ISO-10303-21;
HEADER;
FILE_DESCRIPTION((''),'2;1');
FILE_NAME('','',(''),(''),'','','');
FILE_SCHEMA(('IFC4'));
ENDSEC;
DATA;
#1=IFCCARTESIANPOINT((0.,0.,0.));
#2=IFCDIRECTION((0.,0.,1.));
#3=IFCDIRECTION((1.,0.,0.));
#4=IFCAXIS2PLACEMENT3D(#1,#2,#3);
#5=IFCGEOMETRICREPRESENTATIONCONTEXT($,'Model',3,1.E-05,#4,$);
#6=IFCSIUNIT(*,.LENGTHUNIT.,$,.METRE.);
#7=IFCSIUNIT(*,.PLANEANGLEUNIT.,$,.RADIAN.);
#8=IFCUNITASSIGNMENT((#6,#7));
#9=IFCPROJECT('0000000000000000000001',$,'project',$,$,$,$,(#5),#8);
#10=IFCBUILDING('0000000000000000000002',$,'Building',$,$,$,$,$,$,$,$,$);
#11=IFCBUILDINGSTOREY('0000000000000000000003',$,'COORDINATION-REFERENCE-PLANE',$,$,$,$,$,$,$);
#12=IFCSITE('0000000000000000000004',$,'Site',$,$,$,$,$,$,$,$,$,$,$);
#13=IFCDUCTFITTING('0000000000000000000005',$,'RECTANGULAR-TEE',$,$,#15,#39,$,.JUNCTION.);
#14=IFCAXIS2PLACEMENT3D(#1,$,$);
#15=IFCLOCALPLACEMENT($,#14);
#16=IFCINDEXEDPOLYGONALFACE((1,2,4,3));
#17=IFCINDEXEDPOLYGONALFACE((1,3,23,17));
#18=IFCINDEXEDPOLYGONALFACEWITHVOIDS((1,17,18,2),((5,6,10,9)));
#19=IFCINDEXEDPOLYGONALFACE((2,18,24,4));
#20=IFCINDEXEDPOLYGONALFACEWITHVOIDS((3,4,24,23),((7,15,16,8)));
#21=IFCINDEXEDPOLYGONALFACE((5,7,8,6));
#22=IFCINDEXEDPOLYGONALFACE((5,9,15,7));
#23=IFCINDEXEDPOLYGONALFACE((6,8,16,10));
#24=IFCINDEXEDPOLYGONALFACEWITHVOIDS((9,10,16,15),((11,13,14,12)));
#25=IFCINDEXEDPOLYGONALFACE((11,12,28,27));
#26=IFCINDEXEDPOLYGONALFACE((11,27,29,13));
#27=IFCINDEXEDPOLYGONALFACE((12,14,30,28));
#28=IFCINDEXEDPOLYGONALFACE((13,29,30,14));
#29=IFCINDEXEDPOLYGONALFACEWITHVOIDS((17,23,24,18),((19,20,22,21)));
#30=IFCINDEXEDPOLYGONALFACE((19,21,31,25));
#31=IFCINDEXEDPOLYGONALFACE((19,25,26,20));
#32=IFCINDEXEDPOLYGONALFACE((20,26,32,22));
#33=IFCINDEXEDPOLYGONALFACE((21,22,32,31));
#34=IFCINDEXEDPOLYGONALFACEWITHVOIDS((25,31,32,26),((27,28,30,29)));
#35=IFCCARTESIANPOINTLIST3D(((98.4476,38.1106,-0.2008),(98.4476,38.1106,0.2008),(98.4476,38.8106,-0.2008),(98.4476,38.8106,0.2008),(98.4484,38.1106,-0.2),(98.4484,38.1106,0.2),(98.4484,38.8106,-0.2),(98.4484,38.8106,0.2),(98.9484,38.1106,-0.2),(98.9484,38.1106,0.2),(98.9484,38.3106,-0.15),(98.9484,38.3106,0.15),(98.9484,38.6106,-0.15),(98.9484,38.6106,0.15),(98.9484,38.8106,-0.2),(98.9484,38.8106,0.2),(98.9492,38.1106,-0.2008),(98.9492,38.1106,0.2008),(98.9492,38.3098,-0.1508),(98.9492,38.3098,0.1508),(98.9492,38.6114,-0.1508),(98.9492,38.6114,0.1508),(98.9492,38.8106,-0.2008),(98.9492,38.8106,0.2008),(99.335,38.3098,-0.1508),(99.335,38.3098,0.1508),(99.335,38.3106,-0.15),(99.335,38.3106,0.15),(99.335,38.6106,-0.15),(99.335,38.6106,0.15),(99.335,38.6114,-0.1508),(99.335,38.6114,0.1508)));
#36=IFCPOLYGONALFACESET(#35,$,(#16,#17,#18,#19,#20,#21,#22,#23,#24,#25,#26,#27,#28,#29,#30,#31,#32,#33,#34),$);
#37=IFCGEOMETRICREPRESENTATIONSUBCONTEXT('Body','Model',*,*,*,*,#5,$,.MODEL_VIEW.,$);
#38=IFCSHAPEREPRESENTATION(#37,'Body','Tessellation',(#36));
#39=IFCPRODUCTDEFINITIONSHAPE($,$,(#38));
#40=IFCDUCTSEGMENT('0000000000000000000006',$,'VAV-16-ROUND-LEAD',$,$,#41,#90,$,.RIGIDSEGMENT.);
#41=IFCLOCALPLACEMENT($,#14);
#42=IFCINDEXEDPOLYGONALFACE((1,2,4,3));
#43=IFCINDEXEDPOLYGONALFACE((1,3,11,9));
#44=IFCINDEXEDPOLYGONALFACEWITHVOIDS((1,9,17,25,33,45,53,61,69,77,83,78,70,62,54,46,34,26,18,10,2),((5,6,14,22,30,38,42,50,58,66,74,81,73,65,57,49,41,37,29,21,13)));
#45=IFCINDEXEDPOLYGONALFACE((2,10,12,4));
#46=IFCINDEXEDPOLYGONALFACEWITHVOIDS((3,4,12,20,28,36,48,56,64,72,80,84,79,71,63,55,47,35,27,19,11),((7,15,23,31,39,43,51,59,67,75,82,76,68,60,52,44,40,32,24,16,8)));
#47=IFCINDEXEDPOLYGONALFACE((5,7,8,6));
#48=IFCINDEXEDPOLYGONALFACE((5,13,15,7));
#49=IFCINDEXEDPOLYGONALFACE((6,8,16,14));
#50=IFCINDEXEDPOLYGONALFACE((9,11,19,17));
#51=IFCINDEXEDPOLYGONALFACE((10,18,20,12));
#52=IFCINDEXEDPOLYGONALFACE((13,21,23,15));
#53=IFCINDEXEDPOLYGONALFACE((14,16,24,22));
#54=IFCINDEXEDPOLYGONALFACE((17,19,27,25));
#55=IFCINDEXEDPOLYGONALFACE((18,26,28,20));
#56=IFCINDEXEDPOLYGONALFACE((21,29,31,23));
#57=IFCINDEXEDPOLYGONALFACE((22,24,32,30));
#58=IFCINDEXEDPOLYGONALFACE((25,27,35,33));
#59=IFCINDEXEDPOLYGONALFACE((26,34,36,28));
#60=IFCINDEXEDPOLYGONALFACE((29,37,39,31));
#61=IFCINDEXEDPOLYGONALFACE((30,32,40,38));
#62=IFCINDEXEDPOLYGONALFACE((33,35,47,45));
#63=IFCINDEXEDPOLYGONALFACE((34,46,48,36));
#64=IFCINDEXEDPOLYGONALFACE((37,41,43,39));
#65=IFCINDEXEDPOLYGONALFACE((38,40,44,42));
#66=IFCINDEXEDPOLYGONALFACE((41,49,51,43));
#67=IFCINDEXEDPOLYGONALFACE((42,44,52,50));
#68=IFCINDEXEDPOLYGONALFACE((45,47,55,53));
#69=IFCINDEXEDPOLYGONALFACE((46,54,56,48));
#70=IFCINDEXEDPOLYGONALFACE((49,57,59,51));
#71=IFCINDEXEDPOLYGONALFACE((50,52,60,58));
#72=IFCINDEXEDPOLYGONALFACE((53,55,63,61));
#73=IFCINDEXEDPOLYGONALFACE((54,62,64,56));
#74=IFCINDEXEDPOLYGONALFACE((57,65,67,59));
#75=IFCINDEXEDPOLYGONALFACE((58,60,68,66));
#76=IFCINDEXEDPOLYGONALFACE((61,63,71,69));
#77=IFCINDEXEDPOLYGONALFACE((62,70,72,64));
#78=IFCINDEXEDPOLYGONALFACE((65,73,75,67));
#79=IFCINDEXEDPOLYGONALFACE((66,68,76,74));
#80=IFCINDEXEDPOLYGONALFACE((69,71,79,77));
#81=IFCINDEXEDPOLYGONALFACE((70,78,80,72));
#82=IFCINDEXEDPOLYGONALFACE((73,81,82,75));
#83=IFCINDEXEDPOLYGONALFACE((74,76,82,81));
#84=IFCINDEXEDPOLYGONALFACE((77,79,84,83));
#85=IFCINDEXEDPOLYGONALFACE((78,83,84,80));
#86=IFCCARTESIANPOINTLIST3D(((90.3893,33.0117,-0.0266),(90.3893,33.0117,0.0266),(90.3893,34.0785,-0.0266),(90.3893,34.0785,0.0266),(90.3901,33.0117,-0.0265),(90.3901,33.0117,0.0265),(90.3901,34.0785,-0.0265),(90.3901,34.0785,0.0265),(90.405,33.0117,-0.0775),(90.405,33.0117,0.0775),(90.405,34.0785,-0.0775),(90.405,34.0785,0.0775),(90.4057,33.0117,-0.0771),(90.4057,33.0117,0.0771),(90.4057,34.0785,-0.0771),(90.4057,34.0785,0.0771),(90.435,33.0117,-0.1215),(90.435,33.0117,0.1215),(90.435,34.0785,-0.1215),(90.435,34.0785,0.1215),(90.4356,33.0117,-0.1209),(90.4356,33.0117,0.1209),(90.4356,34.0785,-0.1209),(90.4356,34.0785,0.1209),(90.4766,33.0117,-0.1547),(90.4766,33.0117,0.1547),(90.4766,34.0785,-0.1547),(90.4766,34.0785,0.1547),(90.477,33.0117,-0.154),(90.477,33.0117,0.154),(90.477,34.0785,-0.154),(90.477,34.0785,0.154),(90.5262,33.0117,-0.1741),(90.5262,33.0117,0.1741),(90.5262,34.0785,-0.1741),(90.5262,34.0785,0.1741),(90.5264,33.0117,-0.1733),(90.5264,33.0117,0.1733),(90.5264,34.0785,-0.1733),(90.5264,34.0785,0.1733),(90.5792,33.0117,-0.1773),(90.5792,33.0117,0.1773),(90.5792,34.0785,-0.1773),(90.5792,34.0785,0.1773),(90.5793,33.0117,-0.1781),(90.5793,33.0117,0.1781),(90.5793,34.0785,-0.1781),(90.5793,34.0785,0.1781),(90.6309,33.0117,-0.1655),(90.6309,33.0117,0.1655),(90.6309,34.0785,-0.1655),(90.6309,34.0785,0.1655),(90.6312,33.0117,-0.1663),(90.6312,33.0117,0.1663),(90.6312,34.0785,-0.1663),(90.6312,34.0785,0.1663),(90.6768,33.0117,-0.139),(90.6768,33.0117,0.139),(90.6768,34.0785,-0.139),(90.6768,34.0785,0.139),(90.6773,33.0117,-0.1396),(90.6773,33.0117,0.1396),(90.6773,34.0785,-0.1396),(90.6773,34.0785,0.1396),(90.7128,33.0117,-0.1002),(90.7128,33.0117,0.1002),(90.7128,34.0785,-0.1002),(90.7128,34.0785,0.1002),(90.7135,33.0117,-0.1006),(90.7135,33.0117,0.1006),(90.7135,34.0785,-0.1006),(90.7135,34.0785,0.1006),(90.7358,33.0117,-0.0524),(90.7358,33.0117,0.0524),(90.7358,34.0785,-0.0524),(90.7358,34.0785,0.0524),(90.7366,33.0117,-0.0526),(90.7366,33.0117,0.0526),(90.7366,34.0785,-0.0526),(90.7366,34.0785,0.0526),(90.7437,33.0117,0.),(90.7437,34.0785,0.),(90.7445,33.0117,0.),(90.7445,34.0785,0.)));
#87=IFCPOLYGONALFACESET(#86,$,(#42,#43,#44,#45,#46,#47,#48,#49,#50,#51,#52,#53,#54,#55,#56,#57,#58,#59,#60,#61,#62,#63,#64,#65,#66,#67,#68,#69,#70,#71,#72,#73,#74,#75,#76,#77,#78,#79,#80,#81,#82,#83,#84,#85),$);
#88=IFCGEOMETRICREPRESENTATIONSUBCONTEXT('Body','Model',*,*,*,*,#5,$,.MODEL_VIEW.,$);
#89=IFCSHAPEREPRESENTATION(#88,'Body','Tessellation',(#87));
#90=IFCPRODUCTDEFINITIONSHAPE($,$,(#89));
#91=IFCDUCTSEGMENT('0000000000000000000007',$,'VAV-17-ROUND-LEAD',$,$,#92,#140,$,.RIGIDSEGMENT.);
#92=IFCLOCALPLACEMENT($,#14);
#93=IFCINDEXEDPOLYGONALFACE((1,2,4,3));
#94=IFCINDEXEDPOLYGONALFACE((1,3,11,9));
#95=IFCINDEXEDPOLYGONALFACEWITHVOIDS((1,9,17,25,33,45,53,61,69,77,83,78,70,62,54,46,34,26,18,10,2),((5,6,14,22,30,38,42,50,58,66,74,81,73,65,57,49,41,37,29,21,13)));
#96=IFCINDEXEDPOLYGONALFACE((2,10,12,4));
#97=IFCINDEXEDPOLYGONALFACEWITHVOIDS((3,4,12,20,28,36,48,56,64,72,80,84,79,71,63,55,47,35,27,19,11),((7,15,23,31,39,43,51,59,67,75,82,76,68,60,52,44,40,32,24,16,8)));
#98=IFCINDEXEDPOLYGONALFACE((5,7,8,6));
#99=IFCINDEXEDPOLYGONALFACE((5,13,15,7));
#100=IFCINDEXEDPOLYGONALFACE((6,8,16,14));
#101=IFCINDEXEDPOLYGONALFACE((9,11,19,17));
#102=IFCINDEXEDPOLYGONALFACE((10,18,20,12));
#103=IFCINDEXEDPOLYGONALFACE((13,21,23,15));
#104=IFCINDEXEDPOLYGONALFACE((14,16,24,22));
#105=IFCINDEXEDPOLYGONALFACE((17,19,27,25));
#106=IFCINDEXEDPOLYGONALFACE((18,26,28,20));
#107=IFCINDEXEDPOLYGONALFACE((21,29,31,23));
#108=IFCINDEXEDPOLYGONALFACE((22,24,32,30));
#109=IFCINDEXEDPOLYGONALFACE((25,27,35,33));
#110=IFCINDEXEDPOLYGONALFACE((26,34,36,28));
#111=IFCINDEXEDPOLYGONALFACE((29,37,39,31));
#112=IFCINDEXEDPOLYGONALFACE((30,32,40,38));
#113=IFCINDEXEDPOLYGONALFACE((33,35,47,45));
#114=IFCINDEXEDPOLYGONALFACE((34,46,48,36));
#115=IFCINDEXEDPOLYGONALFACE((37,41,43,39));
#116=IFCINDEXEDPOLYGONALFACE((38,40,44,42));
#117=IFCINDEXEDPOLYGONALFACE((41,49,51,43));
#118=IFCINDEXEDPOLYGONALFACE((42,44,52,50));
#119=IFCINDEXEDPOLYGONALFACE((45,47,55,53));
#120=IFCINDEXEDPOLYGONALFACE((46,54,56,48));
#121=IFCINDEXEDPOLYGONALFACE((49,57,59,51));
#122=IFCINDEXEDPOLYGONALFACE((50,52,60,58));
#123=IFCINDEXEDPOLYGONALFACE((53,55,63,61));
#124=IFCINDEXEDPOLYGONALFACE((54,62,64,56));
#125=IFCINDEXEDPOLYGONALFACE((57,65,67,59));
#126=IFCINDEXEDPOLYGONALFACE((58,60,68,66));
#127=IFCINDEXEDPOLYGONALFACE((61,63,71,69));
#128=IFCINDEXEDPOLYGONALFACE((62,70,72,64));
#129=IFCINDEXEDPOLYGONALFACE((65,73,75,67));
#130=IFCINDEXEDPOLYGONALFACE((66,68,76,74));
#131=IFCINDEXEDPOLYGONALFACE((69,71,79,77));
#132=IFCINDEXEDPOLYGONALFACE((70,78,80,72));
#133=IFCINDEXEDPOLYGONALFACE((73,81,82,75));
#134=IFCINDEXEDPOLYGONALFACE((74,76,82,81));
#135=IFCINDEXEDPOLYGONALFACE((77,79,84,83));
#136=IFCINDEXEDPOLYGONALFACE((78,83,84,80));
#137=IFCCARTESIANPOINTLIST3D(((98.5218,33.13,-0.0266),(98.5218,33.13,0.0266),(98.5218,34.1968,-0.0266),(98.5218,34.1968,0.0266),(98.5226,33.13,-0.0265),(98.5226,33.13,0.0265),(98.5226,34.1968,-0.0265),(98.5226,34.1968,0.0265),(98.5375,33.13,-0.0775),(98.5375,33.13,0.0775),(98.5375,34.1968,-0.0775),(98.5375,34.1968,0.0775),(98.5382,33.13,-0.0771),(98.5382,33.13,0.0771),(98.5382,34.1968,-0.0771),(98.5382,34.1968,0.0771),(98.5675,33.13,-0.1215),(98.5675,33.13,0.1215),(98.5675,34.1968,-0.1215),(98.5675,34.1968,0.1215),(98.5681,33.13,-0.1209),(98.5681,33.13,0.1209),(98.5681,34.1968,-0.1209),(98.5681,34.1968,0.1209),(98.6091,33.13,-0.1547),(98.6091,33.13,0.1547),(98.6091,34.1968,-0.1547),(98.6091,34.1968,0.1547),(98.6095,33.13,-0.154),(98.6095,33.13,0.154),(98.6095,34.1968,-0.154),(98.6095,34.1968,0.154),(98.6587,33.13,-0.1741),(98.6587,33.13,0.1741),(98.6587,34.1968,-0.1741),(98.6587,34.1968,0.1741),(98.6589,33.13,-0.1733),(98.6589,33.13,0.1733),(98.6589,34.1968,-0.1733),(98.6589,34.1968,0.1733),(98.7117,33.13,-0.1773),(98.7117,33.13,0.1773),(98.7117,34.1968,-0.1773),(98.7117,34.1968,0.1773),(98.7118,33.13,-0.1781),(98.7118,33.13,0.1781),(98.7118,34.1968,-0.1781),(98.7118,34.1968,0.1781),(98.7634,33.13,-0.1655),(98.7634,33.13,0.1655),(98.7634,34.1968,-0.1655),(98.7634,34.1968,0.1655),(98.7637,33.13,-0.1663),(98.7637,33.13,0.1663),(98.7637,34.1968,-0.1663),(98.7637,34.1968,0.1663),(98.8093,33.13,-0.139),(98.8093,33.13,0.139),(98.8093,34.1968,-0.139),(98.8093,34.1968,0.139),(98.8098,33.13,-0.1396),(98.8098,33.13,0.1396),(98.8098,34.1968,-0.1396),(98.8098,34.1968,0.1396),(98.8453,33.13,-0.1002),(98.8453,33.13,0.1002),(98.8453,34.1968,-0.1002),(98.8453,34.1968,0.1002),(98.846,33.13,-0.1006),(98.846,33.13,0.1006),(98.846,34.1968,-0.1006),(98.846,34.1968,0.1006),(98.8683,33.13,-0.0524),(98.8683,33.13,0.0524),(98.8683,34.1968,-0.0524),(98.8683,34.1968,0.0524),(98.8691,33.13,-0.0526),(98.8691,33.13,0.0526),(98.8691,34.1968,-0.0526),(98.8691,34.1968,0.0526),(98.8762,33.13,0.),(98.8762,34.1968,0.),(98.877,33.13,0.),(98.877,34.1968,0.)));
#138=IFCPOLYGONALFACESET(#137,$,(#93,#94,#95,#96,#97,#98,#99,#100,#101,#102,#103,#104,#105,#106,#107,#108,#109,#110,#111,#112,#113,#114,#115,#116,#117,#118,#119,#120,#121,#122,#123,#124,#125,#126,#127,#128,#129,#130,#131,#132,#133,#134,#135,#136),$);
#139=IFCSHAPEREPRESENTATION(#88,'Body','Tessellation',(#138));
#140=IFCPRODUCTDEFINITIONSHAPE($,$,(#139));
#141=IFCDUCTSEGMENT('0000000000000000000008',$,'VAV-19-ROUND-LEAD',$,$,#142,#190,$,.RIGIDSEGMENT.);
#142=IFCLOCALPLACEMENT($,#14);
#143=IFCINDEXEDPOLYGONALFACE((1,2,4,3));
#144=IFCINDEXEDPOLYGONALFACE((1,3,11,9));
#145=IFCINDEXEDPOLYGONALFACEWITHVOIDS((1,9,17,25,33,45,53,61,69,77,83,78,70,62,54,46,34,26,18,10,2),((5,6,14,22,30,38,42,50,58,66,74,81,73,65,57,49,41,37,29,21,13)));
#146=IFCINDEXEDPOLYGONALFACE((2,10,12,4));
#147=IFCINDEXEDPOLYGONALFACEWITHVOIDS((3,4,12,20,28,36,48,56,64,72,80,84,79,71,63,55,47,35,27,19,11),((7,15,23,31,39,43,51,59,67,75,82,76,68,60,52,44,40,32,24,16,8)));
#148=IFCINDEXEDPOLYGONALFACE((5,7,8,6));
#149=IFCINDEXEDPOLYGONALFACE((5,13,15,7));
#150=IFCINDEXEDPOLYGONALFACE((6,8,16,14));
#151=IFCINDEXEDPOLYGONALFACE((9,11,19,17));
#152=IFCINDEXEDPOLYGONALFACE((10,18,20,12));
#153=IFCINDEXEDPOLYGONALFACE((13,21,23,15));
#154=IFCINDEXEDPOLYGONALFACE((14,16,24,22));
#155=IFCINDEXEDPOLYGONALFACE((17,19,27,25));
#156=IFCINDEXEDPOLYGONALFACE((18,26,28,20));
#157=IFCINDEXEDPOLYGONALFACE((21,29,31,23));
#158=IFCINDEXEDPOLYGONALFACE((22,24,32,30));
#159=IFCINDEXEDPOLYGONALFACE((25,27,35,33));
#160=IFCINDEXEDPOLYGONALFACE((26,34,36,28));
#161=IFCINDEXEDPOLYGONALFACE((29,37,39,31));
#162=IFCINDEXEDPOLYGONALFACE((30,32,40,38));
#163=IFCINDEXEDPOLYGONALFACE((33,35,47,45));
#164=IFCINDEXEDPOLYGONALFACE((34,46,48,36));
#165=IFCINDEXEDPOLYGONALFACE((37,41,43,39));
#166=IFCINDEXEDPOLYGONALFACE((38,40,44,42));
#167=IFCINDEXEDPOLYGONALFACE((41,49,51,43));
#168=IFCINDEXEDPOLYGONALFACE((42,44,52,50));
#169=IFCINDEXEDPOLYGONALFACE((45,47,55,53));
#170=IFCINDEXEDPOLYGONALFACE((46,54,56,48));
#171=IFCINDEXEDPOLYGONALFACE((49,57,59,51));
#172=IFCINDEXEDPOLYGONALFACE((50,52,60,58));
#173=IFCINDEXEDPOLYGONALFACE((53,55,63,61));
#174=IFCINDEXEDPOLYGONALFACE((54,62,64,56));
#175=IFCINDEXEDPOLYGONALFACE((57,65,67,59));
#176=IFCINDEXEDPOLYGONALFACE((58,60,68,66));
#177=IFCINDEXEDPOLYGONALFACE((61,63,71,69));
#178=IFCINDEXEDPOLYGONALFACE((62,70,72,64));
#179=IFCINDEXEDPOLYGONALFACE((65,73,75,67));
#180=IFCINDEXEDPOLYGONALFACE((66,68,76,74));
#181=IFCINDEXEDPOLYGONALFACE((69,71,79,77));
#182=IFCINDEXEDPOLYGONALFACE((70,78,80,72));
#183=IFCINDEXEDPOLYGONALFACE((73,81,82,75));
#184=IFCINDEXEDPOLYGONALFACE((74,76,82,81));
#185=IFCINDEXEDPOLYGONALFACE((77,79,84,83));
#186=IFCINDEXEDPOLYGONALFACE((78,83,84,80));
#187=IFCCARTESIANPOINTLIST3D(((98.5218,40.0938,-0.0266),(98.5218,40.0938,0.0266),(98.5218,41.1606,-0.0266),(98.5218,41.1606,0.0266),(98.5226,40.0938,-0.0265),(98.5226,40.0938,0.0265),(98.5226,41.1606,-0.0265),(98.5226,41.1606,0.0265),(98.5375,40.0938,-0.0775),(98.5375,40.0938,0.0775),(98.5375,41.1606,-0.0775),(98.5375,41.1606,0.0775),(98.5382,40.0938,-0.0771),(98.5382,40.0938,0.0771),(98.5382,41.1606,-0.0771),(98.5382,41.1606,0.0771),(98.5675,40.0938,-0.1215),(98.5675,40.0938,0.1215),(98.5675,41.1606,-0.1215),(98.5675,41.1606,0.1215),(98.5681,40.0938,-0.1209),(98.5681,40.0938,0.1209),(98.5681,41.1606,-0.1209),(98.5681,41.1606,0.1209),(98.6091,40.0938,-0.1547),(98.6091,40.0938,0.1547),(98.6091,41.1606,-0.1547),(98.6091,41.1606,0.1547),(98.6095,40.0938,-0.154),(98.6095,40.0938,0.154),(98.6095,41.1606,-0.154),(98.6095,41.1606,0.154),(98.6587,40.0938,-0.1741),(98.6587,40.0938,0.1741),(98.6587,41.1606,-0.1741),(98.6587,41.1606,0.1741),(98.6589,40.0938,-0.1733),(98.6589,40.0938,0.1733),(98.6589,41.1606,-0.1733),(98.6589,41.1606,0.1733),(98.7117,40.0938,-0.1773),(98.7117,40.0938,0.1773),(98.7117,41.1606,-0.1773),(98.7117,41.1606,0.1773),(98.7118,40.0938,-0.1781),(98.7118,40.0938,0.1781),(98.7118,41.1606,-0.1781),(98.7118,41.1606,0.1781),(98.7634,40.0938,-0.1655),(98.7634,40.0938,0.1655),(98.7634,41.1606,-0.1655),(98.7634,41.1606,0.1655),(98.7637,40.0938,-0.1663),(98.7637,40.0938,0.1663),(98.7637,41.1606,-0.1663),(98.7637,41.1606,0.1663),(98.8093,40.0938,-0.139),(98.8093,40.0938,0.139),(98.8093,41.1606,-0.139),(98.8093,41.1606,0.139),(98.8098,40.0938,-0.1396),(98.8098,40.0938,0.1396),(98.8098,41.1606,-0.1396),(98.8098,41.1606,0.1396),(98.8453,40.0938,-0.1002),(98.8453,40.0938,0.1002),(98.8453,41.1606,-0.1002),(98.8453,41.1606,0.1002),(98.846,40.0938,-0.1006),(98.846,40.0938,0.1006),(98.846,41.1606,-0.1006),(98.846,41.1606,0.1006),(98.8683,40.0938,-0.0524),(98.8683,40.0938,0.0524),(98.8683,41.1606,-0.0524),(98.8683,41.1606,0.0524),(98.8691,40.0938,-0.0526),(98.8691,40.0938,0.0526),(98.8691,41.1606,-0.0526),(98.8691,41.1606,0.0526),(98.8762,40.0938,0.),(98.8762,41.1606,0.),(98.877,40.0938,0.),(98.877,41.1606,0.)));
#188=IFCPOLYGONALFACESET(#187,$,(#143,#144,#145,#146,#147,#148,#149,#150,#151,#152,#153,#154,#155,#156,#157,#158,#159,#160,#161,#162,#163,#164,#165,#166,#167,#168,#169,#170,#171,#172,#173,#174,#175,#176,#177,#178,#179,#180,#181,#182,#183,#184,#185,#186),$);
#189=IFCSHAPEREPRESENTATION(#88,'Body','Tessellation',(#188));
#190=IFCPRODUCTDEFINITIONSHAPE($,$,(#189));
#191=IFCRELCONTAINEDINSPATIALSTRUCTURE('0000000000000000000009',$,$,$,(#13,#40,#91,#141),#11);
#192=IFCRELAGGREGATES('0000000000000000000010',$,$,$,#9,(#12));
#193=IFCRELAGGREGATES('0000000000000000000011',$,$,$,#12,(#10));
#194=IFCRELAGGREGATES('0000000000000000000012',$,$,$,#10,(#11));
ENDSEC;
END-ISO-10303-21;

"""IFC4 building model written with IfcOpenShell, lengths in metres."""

from ifc_helpers import new_model, si_unit, frame, origin, origin_with_axes, place, context, subcontext, project, spatial, rectangle, hollow_circle, extrude, boolean, element, save


model = new_model("IFC4")

# Units and contexts
model_context = context("Model", 3, precision=1e-05, world=origin_with_axes())
body_context_1 = subcontext(model_context, "Body", "Model", "MODEL_VIEW")
body_context_2 = subcontext(model_context, "Body", "Model", "MODEL_VIEW")
ifc_project = project(units=[si_unit("LENGTHUNIT", "METRE"), si_unit("PLANEANGLEUNIT", "RADIAN")], contexts=[model_context])

# Site, building, storey
site = spatial("IfcSite", under=ifc_project, Name="Site")
building = spatial("IfcBuilding", under=site, Name="Building")
storey = spatial("IfcBuildingStorey", under=building, Name="COORDINATION-REFERENCE-PLANE")

# Duct fitting
duct_fitting_1_placement = place(None, frame((98.6984, 38.4606, 0.0), z_axis=(0.0, 1.0, 0.0), x_axis=(1.0, 0.0, 0.0)))
solid_1 = boolean("UNION", extrude(rectangle(XDim=0.5, YDim=0.4), frame((0.0, 0.0, -0.35), z_axis=(0.0, 0.0, 1.0), x_axis=(1.0, 0.0, 0.0)), (0.0, 0.0, 1.0), 0.7), extrude(rectangle(XDim=0.3, YDim=0.3), frame((0.0, 0.0, 0.0), z_axis=(1.0, 0.0, 0.0), x_axis=(0.0, 0.0, -1.0)), (0.0, 0.0, 1.0), 0.6366))
element("IfcDuctFitting", 1, at=duct_fitting_1_placement, inside=storey, Name="RECTANGULAR-TEE", PredefinedType="JUNCTION", context=body_context_1, shape_type="CSG", body=[
    boolean("DIFFERENCE", boolean("UNION", extrude(rectangle(XDim=0.5016, YDim=0.4016), frame((0.0, 0.0, -0.35), z_axis=(0.0, 0.0, 1.0), x_axis=(1.0, 0.0, 0.0)), (0.0, 0.0, 1.0), 0.7), extrude(rectangle(XDim=0.3016, YDim=0.3016), frame((0.0, 0.0, 0.0), z_axis=(1.0, 0.0, 0.0), x_axis=(0.0, 0.0, -1.0)), (0.0, 0.0, 1.0), 0.6366)), solid_1),
])

# Duct segments
for number, where, z_axis, x_axis, name in (
    (2, (90.5659, 34.0785, 0.0), (0.0, -1.0, 0.0), (1.0, 0.0, 0.0), "VAV-16-ROUND-LEAD"),
    (3, (98.6984, 34.1968, 0.0), (0.0, -1.0, 0.0), (1.0, 0.0, 0.0), "VAV-17-ROUND-LEAD"),
    (4, (98.6984, 40.0938, 0.0), (0.0, 1.0, 0.0), (1.0, 0.0, 0.0), "VAV-19-ROUND-LEAD"),
):
    element("IfcDuctSegment", number, at=place(None, frame(where, z_axis=z_axis, x_axis=x_axis)), inside=storey, Name=name, PredefinedType="RIGIDSEGMENT", context=body_context_2, shape_type="SweptSolid", body=[
        extrude(hollow_circle(Radius=0.1786, WallThickness=0.0008), origin(), (0.0, 0.0, 1.0), 1.0668),
    ])

save(model, "model.ifc")
